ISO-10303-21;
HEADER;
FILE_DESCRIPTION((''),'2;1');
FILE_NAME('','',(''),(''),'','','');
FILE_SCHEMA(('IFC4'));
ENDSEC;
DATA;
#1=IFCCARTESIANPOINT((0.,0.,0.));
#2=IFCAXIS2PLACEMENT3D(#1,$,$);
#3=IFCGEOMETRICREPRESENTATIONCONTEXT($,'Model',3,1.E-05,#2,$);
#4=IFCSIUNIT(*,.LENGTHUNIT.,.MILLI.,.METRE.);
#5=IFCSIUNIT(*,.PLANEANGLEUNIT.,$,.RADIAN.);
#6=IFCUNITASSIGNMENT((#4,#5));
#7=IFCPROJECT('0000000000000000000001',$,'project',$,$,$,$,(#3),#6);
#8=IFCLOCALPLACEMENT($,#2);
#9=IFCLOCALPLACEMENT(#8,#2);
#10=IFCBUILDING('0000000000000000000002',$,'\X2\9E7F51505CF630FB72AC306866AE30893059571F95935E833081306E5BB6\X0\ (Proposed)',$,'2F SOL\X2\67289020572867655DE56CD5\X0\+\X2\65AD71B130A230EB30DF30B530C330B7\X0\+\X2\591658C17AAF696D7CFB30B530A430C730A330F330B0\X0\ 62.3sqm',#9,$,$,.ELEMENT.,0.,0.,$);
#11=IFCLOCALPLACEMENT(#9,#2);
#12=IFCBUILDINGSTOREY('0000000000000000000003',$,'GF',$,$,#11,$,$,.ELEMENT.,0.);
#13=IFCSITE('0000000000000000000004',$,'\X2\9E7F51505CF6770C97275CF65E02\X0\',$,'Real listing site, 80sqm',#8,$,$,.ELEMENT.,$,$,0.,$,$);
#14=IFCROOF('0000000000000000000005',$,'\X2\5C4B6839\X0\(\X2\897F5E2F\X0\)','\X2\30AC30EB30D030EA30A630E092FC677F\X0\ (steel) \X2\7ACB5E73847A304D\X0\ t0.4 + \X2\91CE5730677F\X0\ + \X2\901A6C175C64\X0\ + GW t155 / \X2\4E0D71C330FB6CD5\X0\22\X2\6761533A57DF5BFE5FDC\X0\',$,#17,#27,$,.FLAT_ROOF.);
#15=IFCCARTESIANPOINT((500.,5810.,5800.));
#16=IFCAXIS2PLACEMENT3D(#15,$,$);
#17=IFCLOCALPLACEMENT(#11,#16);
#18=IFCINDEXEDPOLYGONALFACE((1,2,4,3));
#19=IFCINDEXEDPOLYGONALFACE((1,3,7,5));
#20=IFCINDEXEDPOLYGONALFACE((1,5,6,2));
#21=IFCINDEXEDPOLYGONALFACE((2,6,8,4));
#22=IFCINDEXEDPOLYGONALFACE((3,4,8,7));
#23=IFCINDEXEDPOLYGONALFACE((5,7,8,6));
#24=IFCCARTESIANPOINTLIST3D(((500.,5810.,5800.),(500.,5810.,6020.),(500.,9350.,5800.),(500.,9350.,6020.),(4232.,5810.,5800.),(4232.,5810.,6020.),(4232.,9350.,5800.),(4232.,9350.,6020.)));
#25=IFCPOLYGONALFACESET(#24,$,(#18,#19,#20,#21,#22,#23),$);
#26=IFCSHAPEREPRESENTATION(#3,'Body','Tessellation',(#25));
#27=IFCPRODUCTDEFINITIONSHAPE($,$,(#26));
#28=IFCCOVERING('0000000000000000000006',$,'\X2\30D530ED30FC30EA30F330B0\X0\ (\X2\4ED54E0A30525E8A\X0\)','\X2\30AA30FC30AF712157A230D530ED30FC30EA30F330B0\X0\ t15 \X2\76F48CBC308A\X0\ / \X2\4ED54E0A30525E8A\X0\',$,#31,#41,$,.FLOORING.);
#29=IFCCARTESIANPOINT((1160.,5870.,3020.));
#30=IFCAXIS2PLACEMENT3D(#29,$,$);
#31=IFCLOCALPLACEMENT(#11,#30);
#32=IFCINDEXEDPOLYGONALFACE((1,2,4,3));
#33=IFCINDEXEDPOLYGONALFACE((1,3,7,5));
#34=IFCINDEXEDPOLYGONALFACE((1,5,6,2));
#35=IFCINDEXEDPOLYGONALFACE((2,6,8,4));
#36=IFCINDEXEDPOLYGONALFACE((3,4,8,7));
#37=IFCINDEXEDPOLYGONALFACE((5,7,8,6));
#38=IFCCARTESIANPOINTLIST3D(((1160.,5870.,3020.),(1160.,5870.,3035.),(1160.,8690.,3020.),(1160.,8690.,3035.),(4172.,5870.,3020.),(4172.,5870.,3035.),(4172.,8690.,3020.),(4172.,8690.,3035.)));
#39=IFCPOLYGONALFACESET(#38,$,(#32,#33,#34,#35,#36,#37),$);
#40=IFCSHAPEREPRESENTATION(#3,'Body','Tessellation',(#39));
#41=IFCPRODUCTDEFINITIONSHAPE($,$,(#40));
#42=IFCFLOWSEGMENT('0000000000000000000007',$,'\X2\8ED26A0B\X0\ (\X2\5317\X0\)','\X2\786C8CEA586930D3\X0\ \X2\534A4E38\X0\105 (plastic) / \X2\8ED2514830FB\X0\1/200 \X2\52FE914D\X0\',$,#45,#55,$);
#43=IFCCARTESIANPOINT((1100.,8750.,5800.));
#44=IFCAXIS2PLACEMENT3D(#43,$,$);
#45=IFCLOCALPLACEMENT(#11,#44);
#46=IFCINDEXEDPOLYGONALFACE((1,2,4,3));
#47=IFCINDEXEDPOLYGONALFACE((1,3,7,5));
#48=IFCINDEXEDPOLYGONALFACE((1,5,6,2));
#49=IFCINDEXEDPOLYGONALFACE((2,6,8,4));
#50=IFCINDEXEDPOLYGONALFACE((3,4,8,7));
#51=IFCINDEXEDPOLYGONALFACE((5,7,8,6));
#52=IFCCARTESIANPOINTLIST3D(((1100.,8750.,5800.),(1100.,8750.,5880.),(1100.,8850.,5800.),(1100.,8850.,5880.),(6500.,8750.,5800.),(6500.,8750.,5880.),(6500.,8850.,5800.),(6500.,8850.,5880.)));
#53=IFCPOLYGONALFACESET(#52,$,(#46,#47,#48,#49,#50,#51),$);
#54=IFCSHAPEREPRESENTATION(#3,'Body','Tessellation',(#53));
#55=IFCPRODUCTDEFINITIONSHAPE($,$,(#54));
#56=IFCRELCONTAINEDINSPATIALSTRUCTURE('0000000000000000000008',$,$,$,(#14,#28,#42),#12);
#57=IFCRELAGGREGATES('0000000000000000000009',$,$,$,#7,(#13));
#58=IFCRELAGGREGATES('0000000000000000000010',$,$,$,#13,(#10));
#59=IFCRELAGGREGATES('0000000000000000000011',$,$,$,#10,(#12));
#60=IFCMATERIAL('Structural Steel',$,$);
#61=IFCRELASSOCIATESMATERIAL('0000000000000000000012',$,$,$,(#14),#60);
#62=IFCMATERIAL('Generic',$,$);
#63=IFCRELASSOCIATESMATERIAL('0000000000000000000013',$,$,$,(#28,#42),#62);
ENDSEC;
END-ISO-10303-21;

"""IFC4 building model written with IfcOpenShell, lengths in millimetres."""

from ifc_helpers import new_model, si_unit, frame, frame_2d, origin, place, context, project, spatial, rectangle, extrude, material, element, save


model = new_model("IFC4")

# Units and contexts
model_context = context("Model", 3, precision=1e-05, world=origin())
ifc_project = project(units=[si_unit("LENGTHUNIT", "METRE", prefix="MILLI"), si_unit("PLANEANGLEUNIT", "RADIAN")], contexts=[model_context])

# Site, building, storey
site_placement = place(None, origin())
site = spatial("IfcSite", under=ifc_project, at=site_placement, Name="鹿児島県霧島市", ObjectType="Real listing site, 80sqm", CompositionType="ELEMENT", RefElevation=0.0)
building_placement = place(site_placement, origin())
building = spatial("IfcBuilding", under=site, at=building_placement, Name="鹿児島・犬と暮らす土間広めの家 (Proposed)", ObjectType="2F SOL木造在来工法+断熱アルミサッシ+外壁窯業系サイディング 62.3sqm", CompositionType="ELEMENT", ElevationOfRefHeight=0.0, ElevationOfTerrain=0.0)
storey_placement = place(building_placement, origin())
storey = spatial("IfcBuildingStorey", under=building, at=storey_placement, Name="GF", CompositionType="ELEMENT", Elevation=0.0)

# Roof
ifc_material_1 = material(Name="Structural Steel")
for number, where, name in (
    (1, (500.0, 5810.0, 5800.0), "屋根(西帯)"),
):
    element("IfcRoof", number, at=place(storey_placement, frame(where)), inside=storey, material=ifc_material_1, Name=name, Description="ガルバリウム鋼板 (steel) 立平葺き t0.4 + 野地板 + 通気層 + GW t155 / 不燃・法22条区域対応", PredefinedType="FLAT_ROOF", context=model_context, shape_type="SweptSolid", body=[
        extrude(rectangle(XDim=3732.0, YDim=3540.0, at=frame_2d((1866.0, 1770.0))), frame((500.0, 5810.0, 5800.0)), (0.0, 0.0, 1.0), 220.0),
    ])

# Covering
ifc_material_2 = material(Name="Generic")
covering_placement = place(storey_placement, frame((1160.0, 5870.0, 3020.0)))
element("IfcCovering", 2, at=covering_placement, inside=storey, material=ifc_material_2, Name="フローリング (仕上げ床)", Description="オーク無垢フローリング t15 直貼り / 仕上げ床", PredefinedType="FLOORING", context=model_context, shape_type="SweptSolid", body=[
    extrude(rectangle(XDim=3012.0, YDim=2820.0, at=frame_2d((1506.0, 1410.0))), frame((1160.0, 5870.0, 3020.0)), (0.0, 0.0, 1.0), 15.0),
])

# Flow segment
flow_segment_placement = place(storey_placement, frame((1100.0, 8750.0, 5800.0)))
element("IfcFlowSegment", 3, at=flow_segment_placement, inside=storey, material=ifc_material_2, Name="軒樋 (北)", Description="硬質塩ビ 半丸105 (plastic) / 軒先・1/200 勾配", context=model_context, shape_type="SweptSolid", body=[
    extrude(rectangle(XDim=5400.0, YDim=100.0, at=frame_2d((2700.0, 50.0))), frame((1100.0, 8750.0, 5800.0)), (0.0, 0.0, 1.0), 80.0),
])

save(model, "model.ifc")
